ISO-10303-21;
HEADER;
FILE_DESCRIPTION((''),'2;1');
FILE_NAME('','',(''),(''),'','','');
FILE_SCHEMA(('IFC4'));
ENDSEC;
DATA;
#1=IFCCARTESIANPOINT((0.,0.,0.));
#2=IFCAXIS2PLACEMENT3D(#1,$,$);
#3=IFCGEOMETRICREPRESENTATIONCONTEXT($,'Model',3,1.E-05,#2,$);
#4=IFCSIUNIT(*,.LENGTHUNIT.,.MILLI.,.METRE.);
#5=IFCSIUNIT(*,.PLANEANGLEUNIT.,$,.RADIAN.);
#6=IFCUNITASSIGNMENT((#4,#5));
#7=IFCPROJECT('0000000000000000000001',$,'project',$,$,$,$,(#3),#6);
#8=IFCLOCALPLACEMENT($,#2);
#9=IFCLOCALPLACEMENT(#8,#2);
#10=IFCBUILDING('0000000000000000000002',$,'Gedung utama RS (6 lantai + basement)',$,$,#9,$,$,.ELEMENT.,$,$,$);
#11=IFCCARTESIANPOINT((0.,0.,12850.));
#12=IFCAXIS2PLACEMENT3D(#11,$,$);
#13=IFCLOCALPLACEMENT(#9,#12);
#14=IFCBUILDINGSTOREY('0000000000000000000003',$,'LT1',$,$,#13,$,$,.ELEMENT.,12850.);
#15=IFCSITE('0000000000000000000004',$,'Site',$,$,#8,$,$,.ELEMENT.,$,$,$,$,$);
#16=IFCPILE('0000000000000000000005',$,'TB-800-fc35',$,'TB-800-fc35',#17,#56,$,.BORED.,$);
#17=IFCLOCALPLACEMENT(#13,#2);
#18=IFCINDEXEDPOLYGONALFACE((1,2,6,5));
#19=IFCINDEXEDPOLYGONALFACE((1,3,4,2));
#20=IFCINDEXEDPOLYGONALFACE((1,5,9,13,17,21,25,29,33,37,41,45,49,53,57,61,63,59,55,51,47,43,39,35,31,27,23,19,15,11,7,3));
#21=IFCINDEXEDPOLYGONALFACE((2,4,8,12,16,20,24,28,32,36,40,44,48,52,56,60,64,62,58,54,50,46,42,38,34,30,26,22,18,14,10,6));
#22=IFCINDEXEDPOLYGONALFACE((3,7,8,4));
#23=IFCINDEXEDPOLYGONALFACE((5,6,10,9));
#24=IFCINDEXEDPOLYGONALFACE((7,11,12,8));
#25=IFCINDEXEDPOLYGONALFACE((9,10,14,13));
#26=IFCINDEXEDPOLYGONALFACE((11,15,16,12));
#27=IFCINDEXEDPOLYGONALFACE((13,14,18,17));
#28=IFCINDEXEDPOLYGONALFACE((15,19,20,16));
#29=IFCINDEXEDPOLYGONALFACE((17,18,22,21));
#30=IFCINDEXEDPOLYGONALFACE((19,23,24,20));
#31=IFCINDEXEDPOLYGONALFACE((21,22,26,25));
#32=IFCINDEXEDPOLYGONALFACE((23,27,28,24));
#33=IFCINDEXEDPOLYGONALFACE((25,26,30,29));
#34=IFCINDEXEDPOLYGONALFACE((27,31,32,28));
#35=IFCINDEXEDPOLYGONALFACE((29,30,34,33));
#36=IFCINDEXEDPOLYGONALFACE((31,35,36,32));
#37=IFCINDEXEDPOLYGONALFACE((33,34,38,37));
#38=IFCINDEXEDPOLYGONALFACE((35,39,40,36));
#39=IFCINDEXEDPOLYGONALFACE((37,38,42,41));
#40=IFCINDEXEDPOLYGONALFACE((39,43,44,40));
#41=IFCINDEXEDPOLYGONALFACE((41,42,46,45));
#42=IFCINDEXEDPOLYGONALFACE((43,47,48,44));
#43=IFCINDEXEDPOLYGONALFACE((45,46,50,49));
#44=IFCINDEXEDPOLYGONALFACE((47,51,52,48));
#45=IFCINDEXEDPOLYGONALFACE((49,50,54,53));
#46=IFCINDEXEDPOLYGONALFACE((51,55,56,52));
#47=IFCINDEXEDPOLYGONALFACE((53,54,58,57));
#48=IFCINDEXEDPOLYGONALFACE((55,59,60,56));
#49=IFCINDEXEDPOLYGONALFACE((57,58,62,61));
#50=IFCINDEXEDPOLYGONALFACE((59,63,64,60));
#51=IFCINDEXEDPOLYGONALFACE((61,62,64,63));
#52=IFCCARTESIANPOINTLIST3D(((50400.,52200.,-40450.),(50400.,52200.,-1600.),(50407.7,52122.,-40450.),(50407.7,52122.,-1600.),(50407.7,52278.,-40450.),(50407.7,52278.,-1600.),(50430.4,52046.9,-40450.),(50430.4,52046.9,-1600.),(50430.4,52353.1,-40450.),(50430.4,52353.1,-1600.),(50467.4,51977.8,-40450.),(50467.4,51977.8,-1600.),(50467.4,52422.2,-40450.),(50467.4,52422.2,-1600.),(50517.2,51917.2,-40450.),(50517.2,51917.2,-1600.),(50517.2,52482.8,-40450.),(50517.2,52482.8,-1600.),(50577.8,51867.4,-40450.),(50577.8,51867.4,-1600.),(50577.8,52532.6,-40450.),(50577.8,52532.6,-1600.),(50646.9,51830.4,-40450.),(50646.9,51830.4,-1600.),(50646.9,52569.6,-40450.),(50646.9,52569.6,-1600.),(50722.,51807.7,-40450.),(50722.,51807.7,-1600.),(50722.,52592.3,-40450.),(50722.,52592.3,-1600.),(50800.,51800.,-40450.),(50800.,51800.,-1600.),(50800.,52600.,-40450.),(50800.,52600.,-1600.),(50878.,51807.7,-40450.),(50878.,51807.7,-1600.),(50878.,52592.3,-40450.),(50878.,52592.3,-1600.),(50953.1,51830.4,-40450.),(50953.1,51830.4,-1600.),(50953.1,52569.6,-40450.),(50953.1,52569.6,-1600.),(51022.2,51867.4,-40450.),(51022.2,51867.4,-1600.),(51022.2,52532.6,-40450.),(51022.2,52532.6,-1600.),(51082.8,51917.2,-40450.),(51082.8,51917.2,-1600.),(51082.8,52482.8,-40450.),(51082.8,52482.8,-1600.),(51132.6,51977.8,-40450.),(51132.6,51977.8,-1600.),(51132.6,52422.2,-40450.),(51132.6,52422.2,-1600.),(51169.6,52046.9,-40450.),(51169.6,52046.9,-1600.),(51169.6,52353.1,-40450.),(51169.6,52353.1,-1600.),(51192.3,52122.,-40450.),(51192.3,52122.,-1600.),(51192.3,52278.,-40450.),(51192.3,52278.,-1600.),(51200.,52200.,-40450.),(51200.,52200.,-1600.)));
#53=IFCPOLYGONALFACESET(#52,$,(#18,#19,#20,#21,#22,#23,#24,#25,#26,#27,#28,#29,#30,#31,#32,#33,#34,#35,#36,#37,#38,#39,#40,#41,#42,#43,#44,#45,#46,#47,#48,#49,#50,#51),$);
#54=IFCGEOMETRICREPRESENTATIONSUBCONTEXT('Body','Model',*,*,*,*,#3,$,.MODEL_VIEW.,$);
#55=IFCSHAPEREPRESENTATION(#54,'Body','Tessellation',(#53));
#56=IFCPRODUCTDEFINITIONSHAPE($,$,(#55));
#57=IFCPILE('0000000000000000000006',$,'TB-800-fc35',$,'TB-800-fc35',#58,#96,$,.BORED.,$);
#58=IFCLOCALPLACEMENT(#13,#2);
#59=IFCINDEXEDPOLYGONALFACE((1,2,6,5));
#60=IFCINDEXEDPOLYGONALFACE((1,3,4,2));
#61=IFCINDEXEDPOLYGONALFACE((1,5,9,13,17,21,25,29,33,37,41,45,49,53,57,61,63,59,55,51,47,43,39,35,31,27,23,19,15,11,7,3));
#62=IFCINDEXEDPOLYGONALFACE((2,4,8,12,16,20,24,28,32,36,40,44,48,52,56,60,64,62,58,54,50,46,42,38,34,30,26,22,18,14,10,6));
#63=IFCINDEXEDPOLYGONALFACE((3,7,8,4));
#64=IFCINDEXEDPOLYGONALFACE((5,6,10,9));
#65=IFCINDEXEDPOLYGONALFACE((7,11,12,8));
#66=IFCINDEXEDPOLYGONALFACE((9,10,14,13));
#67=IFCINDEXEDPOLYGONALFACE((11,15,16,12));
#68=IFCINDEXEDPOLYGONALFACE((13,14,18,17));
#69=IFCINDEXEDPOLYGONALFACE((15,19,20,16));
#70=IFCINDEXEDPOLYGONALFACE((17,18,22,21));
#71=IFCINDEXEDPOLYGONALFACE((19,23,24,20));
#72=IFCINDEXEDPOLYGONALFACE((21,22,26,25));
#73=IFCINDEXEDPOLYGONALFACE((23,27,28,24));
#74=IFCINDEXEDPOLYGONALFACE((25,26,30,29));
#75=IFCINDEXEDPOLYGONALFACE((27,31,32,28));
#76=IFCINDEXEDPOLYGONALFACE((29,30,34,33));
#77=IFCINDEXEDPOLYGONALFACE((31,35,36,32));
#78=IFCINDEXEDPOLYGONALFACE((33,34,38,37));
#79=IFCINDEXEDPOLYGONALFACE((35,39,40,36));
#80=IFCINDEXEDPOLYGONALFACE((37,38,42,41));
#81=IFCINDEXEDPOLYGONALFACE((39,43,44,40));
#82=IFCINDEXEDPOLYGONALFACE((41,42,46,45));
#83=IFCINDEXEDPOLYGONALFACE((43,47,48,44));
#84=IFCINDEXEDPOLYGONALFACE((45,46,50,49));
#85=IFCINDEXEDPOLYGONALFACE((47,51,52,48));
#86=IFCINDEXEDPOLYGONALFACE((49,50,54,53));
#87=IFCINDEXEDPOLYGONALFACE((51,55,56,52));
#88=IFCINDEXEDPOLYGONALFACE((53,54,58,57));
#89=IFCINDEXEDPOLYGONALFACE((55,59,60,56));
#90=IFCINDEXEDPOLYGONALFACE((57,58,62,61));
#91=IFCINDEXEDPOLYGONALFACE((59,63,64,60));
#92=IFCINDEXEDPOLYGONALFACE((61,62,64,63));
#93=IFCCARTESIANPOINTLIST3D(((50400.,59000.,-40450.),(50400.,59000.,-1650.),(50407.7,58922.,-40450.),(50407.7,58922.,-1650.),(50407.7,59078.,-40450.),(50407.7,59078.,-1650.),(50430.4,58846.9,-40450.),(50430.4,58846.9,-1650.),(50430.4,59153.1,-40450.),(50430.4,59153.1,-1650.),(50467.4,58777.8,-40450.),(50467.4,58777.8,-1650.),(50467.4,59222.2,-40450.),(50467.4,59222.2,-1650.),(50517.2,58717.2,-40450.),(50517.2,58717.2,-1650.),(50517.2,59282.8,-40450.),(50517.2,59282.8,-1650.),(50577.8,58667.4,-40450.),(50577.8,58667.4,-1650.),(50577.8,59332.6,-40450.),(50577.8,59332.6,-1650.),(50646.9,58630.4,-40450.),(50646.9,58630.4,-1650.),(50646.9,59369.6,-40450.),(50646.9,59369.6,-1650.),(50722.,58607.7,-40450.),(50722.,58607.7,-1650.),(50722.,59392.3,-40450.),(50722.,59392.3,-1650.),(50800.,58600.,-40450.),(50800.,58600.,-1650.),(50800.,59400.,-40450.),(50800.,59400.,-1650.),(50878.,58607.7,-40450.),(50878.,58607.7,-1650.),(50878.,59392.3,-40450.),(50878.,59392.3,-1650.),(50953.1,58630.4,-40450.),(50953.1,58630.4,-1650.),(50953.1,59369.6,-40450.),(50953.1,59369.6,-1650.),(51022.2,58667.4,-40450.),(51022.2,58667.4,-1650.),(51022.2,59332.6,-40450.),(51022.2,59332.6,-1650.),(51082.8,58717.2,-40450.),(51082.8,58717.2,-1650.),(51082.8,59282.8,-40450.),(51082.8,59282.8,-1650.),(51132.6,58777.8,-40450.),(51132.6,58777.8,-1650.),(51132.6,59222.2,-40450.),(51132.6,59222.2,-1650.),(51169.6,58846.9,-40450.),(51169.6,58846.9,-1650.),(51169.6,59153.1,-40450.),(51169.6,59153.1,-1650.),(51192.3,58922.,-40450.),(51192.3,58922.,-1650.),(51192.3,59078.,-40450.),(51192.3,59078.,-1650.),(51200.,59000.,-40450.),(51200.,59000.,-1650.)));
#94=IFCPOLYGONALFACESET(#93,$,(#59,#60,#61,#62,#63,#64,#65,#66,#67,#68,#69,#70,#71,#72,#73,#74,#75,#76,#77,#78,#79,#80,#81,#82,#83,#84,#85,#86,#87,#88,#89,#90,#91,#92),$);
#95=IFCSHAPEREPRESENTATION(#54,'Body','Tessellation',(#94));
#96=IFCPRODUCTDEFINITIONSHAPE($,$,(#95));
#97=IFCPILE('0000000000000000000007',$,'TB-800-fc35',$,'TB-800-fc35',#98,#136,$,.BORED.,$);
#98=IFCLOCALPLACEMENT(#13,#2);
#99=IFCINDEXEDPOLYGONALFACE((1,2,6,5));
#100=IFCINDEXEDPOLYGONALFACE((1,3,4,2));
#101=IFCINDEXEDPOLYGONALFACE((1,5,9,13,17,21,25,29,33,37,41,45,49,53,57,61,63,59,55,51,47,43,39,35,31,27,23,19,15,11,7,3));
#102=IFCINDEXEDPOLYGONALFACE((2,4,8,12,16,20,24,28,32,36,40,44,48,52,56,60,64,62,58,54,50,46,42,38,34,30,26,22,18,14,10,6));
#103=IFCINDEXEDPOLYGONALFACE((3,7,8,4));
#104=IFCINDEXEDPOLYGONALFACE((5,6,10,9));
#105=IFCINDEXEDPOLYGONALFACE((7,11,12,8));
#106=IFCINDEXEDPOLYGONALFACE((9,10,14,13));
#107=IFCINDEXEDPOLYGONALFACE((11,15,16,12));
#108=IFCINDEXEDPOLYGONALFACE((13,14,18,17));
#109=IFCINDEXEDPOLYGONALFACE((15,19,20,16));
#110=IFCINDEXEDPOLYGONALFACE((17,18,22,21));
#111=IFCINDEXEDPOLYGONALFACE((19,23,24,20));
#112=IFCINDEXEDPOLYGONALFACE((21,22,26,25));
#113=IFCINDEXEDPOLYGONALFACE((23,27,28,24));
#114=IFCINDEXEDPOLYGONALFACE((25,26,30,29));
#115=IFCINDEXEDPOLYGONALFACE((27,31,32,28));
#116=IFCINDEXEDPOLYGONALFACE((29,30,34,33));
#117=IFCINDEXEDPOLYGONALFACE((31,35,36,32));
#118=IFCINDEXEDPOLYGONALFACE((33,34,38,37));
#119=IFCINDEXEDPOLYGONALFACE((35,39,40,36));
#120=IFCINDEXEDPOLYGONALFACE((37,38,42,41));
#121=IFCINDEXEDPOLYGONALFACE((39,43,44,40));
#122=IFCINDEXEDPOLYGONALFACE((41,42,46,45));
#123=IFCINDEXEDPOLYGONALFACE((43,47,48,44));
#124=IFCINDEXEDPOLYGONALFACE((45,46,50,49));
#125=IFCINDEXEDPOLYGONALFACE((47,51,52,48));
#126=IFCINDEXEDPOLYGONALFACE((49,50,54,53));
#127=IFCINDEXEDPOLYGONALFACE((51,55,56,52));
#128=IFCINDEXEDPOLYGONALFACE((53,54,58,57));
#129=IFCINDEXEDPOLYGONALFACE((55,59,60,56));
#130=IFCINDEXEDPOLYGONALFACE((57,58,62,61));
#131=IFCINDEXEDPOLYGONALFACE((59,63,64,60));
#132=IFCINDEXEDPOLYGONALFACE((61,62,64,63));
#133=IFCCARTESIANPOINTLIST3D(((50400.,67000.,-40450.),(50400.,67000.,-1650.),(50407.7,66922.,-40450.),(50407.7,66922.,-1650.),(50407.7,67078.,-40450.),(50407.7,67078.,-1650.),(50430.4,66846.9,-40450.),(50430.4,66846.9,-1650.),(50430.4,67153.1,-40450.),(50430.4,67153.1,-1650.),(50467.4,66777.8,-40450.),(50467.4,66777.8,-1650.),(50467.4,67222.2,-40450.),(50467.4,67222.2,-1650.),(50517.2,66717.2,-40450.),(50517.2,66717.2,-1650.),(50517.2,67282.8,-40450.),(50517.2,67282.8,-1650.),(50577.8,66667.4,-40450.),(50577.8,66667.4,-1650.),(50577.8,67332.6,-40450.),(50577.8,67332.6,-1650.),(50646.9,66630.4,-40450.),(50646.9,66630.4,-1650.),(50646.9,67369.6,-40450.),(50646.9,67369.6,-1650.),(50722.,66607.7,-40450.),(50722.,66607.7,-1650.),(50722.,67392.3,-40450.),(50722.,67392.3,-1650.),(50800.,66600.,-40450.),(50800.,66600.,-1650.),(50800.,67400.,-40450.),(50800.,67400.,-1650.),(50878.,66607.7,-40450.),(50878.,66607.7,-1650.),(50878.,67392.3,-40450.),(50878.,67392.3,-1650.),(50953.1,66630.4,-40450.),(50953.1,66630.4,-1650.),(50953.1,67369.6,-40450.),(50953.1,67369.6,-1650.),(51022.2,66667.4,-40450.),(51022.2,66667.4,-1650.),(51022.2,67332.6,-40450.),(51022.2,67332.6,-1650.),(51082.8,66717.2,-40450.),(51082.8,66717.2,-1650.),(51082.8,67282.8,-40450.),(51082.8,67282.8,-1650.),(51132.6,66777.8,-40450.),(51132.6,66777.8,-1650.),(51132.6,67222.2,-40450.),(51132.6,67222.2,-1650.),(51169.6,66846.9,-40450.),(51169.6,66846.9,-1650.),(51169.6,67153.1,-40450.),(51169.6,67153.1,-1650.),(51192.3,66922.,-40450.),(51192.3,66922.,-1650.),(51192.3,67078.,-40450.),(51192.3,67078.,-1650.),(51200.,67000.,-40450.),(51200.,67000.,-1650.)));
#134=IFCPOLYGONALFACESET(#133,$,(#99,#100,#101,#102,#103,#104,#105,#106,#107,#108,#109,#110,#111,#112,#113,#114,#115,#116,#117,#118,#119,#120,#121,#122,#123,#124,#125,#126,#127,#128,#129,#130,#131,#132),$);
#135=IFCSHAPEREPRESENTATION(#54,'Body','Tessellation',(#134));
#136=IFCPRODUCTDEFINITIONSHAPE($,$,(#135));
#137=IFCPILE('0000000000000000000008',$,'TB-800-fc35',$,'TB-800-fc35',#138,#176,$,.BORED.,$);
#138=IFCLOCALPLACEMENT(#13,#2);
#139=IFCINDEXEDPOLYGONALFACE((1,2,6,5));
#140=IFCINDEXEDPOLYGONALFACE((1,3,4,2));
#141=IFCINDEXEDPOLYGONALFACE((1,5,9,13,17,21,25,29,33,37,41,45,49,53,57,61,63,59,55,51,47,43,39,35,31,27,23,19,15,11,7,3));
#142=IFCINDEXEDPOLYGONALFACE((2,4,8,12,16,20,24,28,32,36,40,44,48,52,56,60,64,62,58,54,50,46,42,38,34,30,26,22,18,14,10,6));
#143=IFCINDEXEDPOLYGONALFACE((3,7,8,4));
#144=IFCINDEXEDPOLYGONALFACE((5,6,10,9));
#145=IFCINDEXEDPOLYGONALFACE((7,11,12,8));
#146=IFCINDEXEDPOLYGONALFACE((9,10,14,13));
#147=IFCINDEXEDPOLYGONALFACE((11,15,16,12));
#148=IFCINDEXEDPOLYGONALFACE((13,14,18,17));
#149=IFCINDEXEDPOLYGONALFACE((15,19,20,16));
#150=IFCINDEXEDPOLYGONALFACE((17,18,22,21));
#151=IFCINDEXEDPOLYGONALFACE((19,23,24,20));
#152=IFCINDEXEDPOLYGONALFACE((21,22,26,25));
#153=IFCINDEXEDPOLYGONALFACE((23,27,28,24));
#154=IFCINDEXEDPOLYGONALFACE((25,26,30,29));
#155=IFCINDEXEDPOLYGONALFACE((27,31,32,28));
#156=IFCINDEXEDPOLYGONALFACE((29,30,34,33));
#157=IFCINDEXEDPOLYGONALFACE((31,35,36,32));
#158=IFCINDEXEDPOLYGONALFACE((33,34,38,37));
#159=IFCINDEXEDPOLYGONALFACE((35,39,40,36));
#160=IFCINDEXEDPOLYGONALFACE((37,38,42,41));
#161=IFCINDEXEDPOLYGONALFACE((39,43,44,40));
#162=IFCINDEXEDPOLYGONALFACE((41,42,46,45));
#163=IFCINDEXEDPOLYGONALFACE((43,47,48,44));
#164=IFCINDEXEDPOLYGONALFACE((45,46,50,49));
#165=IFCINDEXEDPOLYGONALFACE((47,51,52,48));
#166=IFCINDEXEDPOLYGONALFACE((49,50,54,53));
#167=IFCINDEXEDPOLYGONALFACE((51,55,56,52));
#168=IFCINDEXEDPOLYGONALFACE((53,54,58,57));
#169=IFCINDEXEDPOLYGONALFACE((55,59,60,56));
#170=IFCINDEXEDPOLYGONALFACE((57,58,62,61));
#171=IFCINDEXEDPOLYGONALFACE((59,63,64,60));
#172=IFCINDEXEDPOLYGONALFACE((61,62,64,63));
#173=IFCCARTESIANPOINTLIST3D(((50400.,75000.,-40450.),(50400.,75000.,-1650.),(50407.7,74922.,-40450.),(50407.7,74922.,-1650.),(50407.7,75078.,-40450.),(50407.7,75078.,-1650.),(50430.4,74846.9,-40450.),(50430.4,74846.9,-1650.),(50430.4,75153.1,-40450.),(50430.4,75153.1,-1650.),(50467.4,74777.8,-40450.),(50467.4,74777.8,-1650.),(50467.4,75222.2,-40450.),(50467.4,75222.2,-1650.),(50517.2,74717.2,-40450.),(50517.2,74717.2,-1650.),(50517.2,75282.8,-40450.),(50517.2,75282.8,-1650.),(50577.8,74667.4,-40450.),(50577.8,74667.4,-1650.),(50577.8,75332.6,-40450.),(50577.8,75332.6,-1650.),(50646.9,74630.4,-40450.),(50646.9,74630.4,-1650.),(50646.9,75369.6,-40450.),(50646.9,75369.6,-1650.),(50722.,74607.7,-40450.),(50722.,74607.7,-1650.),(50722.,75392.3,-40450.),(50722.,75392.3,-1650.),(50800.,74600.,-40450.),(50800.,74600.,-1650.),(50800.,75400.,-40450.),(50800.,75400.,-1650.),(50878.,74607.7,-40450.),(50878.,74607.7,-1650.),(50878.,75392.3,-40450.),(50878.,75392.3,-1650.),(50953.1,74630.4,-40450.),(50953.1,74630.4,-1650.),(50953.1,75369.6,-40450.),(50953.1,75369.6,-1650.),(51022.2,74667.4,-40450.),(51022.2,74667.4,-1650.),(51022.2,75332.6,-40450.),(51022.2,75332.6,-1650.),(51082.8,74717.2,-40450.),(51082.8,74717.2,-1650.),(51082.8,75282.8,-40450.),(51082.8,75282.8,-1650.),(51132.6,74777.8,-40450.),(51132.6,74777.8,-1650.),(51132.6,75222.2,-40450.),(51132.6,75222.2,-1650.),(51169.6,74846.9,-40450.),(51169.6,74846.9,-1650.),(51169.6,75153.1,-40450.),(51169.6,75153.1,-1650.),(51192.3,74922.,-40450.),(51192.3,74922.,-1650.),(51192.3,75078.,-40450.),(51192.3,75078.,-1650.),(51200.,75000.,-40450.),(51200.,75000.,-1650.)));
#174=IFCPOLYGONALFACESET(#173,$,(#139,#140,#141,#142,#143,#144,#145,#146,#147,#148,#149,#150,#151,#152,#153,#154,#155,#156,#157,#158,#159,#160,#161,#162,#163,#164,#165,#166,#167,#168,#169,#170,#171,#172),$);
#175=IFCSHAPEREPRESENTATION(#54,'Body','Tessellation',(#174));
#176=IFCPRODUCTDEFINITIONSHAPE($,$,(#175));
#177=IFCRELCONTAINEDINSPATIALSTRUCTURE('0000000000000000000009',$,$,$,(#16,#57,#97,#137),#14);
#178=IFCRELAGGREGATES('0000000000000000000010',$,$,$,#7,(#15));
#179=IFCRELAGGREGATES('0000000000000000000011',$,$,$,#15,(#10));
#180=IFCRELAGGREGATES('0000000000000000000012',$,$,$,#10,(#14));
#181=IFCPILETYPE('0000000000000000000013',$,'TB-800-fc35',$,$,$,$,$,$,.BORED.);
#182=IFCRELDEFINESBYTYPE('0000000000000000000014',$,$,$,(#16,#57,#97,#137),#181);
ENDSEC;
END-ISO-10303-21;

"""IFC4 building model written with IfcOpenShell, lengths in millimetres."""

from ifc_helpers import new_model, si_unit, frame, origin, origin_2d, place, context, subcontext, project, spatial, circle, extrude, material_profile, profile_set, profile_usage, type_object, element, save


model = new_model("IFC4")

# Units and contexts
model_context = context("Model", 3, precision=1e-05, world=origin())
body_context = subcontext(model_context, "Body", "Model", "MODEL_VIEW")
ifc_project = project(units=[si_unit("LENGTHUNIT", "METRE", prefix="MILLI"), si_unit("PLANEANGLEUNIT", "RADIAN")], contexts=[model_context])

# Site, building, storey
site_placement = place(None, origin())
site = spatial("IfcSite", under=ifc_project, at=site_placement, Name="Site", CompositionType="ELEMENT")
building_placement = place(site_placement, origin())
building = spatial("IfcBuilding", under=site, at=building_placement, Name="Gedung utama RS (6 lantai + basement)", CompositionType="ELEMENT")
storey_placement = place(building_placement, frame((0.0, 0.0, 12850.0)))
storey = spatial("IfcBuildingStorey", under=building, at=storey_placement, Name="LT1", CompositionType="ELEMENT", Elevation=12850.0)

# Piles
ifc_material_profile_1 = material_profile(None, circle(Radius=400.0, at=origin_2d()), Name="TB-800-fc35")
ifc_profile_set_1 = profile_set([ifc_material_profile_1], Name="TB-800-fc35")
ifc_profile_usage_1 = profile_usage(ifc_profile_set_1, cardinal=5)
pile_type = type_object("IfcPileType", Name="TB-800-fc35", PredefinedType="BORED", material=ifc_profile_set_1)
for number, where, z_axis, x_axis, name in (
    (1, (50800.0, 52200.0, -40450.0), (0.0, 0.0, 1.0), (1.0, 0.0, 0.0), "TB-800-fc35"),
):
    element("IfcPile", number, at=place(storey_placement, frame(where, z_axis=z_axis, x_axis=x_axis)), inside=storey, type_object=pile_type, material=ifc_profile_usage_1, Name=name, ObjectType="TB-800-fc35", PredefinedType="BORED", context=body_context, shape_type="SweptSolid", body=[
        extrude(circle(Radius=400.0, at=origin_2d()), origin(), (0.0, 0.0, 1.0), 38850.0),
    ])
for number, where, z_axis, x_axis, name in (
    (2, (50800.0, 59000.0, -40450.0), (0.0, 0.0, 1.0), (1.0, 0.0, 0.0), "TB-800-fc35"),
    (3, (50800.0, 67000.0, -40450.0), (0.0, 0.0, 1.0), (1.0, 0.0, 0.0), "TB-800-fc35"),
    (4, (50800.0, 75000.0, -40450.0), (0.0, 0.0, 1.0), (1.0, 0.0, 0.0), "TB-800-fc35"),
):
    element("IfcPile", number, at=place(storey_placement, frame(where, z_axis=z_axis, x_axis=x_axis)), inside=storey, type_object=pile_type, material=ifc_profile_usage_1, Name=name, ObjectType="TB-800-fc35", PredefinedType="BORED", context=body_context, shape_type="SweptSolid", body=[
        extrude(circle(Radius=400.0, at=origin_2d()), origin(), (0.0, 0.0, 1.0), 38800.0),
    ])

save(model, "model.ifc")
